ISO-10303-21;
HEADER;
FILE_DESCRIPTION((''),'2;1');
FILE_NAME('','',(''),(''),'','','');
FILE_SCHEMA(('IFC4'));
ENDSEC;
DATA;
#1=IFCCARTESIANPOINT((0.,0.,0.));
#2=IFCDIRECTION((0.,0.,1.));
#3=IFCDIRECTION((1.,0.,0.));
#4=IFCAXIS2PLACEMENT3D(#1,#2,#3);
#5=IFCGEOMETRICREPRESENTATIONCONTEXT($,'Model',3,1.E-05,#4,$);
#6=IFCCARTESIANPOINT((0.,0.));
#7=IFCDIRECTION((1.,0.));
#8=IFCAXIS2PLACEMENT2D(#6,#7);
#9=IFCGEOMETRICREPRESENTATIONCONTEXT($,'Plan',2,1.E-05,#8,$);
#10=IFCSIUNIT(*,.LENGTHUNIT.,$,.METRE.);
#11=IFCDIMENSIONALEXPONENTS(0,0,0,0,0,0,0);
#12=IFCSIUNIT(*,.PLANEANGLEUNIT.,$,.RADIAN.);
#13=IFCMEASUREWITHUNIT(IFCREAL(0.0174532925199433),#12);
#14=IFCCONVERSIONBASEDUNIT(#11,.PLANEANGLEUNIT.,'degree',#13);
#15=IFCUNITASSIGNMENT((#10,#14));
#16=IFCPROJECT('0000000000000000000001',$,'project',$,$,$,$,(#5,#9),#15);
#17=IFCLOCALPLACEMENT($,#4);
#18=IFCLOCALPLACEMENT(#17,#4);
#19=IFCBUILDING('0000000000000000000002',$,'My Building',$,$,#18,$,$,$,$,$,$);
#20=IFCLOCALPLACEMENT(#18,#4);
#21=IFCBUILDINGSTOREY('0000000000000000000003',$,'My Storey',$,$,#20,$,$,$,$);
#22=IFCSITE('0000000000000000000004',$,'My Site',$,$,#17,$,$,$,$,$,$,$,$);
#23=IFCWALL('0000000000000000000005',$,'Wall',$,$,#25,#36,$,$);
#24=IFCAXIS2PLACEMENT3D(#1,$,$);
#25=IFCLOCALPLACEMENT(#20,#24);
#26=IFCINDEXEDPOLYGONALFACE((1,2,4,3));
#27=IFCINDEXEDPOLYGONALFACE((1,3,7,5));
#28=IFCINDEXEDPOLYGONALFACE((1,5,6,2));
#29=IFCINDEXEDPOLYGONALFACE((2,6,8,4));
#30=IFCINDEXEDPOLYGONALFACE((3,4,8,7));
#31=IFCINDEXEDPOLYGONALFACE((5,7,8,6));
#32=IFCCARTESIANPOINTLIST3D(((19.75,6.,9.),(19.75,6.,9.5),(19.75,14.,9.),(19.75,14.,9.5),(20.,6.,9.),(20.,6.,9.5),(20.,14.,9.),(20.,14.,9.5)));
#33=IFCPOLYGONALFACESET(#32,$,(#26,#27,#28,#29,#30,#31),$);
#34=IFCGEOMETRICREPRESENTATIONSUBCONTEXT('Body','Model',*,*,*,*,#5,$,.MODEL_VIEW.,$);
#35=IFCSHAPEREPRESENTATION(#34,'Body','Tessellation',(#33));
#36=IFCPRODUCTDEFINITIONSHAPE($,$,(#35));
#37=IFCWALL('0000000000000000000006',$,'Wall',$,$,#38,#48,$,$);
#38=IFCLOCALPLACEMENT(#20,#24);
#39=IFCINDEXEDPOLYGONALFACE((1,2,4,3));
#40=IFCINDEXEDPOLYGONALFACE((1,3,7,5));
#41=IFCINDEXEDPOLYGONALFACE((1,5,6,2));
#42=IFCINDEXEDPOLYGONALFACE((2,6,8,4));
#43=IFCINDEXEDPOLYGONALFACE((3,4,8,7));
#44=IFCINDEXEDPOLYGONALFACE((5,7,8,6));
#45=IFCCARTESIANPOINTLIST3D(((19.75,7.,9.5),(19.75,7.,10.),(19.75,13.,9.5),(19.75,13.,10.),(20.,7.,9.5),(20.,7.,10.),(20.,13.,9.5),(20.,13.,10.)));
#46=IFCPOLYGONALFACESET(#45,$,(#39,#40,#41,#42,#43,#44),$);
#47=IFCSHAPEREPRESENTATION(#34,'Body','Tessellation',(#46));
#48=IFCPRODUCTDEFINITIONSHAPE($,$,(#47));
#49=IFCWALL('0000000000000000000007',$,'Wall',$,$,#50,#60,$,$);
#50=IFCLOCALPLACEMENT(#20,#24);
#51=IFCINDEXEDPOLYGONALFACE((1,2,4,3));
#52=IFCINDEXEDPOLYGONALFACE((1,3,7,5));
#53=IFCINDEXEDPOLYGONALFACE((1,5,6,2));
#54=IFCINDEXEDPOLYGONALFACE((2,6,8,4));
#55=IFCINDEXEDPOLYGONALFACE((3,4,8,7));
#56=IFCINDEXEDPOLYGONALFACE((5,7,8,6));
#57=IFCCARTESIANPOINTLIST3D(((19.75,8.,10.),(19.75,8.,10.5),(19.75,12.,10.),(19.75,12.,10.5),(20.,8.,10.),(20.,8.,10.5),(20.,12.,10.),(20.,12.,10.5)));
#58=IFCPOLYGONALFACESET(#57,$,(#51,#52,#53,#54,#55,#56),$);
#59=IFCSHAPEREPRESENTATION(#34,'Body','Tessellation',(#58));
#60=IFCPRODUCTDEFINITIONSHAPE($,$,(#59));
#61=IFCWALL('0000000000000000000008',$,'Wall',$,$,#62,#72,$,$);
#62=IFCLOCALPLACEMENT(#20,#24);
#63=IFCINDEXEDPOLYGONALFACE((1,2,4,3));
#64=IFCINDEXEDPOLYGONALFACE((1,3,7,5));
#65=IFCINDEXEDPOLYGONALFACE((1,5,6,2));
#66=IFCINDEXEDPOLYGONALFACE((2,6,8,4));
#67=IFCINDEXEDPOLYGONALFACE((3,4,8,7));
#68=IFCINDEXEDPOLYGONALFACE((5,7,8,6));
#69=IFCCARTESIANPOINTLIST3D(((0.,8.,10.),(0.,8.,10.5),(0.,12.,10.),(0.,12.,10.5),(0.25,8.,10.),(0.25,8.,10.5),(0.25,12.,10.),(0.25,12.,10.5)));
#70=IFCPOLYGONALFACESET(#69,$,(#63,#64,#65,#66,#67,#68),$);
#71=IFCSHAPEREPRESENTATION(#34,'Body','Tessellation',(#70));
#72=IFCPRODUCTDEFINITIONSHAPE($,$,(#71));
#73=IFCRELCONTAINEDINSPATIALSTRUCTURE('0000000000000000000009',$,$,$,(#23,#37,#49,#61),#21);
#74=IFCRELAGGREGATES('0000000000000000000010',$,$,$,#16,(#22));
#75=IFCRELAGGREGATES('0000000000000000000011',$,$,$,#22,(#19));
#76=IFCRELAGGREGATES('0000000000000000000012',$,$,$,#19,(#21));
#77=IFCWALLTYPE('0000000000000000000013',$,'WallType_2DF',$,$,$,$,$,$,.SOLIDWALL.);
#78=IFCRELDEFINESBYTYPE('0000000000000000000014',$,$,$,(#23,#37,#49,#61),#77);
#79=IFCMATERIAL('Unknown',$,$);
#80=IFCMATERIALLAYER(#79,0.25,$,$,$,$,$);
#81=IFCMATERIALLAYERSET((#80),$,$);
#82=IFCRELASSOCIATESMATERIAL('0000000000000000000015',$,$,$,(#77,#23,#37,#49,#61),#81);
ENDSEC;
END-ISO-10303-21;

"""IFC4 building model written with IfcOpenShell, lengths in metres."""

from ifc_helpers import new_model, entity, si_unit, converted_unit, frame, origin_with_axes, origin_2d_with_axis, place, context, subcontext, project, spatial, indexed_curve, outline, extrude, material, layer, layer_set, layer_usage, type_object, element, save


model = new_model("IFC4")

# Units and contexts
model_context = context("Model", 3, precision=1e-05, world=origin_with_axes())
plan_context = context("Plan", 2, precision=1e-05, world=origin_2d_with_axis())
body_context_1 = subcontext(model_context, "Body", "Model", "MODEL_VIEW")
ifc_project = project(units=[si_unit("LENGTHUNIT", "METRE"), converted_unit("PLANEANGLEUNIT", "degree", entity("IfcReal", 0.0174532925199433), si_unit("PLANEANGLEUNIT", "RADIAN"), dimensions=[0, 0, 0, 0, 0, 0, 0])], contexts=[model_context, plan_context])

# Site, building, storey
site_placement = place(None, origin_with_axes())
site = spatial("IfcSite", under=ifc_project, at=site_placement, Name="My Site")
building_placement = place(site_placement, origin_with_axes())
building = spatial("IfcBuilding", under=site, at=building_placement, Name="My Building")
storey_placement = place(building_placement, origin_with_axes())
storey = spatial("IfcBuildingStorey", under=building, at=storey_placement, Name="My Storey")

# Shared definitions
ifc_material = material(Name="Unknown")

# Walls
ifc_layer_1 = layer(ifc_material, 0.25)
ifc_layer_set_1 = layer_set([ifc_layer_1])
ifc_layer_usage_1 = layer_usage(ifc_layer_set_1, "AXIS2", "POSITIVE", 0.0)
wall_type_1 = type_object("IfcWallType", Name="WallType_2DF", PredefinedType="SOLIDWALL", material=ifc_layer_set_1)
wall_1_placement = place(storey_placement, frame((20.0, 6.0, 9.0), z_axis=(0.0, 0.0, 1.0), x_axis=(0.0, 1.0, 0.0)))
element("IfcWall", 1, at=wall_1_placement, inside=storey, type_object=wall_type_1, material=ifc_layer_usage_1, Name="Wall", context=body_context_1, shape_type="SweptSolid", body=[
    extrude(outline(indexed_curve([(0.0, 0.0), (0.0, 0.25), (8.0, 0.25), (8.0, 0.0), (0.0, 0.0)], self_intersect=False)), origin_with_axes(), (0.0, 0.0, 1.0), 0.5),
])
ifc_layer_usage_2 = layer_usage(ifc_layer_set_1, "AXIS2", "POSITIVE", 0.0)
wall_2_placement = place(storey_placement, frame((20.0, 7.0, 9.5), z_axis=(0.0, 0.0, 1.0), x_axis=(0.0, 1.0, 0.0)))
element("IfcWall", 2, at=wall_2_placement, inside=storey, type_object=wall_type_1, material=ifc_layer_usage_2, Name="Wall", context=body_context_1, shape_type="SweptSolid", body=[
    extrude(outline(indexed_curve([(0.0, 0.0), (0.0, 0.25), (6.0, 0.25), (6.0, 0.0), (0.0, 0.0)], self_intersect=False)), origin_with_axes(), (0.0, 0.0, 1.0), 0.5),
])
ifc_layer_usage_3 = layer_usage(ifc_layer_set_1, "AXIS2", "POSITIVE", 0.0)
wall_3_placement = place(storey_placement, frame((20.0, 8.0, 10.0), z_axis=(0.0, 0.0, 1.0), x_axis=(0.0, 1.0, 0.0)))
element("IfcWall", 3, at=wall_3_placement, inside=storey, type_object=wall_type_1, material=ifc_layer_usage_3, Name="Wall", context=body_context_1, shape_type="SweptSolid", body=[
    extrude(outline(indexed_curve([(0.0, 0.0), (0.0, 0.25), (4.0, 0.25), (4.0, 0.0), (0.0, 0.0)], self_intersect=False)), origin_with_axes(), (0.0, 0.0, 1.0), 0.5),
])
ifc_layer_usage_4 = layer_usage(ifc_layer_set_1, "AXIS2", "POSITIVE", 0.0)
wall_4_placement = place(storey_placement, frame((0.25, 8.0, 10.0), z_axis=(0.0, 0.0, 1.0), x_axis=(0.0, 1.0, 0.0)))
element("IfcWall", 4, at=wall_4_placement, inside=storey, type_object=wall_type_1, material=ifc_layer_usage_4, Name="Wall", context=body_context_1, shape_type="SweptSolid", body=[
    extrude(outline(indexed_curve([(0.0, 0.0), (0.0, 0.25), (4.0, 0.25), (4.0, 0.0), (0.0, 0.0)], self_intersect=False)), origin_with_axes(), (0.0, 0.0, 1.0), 0.5),
])

save(model, "model.ifc")
